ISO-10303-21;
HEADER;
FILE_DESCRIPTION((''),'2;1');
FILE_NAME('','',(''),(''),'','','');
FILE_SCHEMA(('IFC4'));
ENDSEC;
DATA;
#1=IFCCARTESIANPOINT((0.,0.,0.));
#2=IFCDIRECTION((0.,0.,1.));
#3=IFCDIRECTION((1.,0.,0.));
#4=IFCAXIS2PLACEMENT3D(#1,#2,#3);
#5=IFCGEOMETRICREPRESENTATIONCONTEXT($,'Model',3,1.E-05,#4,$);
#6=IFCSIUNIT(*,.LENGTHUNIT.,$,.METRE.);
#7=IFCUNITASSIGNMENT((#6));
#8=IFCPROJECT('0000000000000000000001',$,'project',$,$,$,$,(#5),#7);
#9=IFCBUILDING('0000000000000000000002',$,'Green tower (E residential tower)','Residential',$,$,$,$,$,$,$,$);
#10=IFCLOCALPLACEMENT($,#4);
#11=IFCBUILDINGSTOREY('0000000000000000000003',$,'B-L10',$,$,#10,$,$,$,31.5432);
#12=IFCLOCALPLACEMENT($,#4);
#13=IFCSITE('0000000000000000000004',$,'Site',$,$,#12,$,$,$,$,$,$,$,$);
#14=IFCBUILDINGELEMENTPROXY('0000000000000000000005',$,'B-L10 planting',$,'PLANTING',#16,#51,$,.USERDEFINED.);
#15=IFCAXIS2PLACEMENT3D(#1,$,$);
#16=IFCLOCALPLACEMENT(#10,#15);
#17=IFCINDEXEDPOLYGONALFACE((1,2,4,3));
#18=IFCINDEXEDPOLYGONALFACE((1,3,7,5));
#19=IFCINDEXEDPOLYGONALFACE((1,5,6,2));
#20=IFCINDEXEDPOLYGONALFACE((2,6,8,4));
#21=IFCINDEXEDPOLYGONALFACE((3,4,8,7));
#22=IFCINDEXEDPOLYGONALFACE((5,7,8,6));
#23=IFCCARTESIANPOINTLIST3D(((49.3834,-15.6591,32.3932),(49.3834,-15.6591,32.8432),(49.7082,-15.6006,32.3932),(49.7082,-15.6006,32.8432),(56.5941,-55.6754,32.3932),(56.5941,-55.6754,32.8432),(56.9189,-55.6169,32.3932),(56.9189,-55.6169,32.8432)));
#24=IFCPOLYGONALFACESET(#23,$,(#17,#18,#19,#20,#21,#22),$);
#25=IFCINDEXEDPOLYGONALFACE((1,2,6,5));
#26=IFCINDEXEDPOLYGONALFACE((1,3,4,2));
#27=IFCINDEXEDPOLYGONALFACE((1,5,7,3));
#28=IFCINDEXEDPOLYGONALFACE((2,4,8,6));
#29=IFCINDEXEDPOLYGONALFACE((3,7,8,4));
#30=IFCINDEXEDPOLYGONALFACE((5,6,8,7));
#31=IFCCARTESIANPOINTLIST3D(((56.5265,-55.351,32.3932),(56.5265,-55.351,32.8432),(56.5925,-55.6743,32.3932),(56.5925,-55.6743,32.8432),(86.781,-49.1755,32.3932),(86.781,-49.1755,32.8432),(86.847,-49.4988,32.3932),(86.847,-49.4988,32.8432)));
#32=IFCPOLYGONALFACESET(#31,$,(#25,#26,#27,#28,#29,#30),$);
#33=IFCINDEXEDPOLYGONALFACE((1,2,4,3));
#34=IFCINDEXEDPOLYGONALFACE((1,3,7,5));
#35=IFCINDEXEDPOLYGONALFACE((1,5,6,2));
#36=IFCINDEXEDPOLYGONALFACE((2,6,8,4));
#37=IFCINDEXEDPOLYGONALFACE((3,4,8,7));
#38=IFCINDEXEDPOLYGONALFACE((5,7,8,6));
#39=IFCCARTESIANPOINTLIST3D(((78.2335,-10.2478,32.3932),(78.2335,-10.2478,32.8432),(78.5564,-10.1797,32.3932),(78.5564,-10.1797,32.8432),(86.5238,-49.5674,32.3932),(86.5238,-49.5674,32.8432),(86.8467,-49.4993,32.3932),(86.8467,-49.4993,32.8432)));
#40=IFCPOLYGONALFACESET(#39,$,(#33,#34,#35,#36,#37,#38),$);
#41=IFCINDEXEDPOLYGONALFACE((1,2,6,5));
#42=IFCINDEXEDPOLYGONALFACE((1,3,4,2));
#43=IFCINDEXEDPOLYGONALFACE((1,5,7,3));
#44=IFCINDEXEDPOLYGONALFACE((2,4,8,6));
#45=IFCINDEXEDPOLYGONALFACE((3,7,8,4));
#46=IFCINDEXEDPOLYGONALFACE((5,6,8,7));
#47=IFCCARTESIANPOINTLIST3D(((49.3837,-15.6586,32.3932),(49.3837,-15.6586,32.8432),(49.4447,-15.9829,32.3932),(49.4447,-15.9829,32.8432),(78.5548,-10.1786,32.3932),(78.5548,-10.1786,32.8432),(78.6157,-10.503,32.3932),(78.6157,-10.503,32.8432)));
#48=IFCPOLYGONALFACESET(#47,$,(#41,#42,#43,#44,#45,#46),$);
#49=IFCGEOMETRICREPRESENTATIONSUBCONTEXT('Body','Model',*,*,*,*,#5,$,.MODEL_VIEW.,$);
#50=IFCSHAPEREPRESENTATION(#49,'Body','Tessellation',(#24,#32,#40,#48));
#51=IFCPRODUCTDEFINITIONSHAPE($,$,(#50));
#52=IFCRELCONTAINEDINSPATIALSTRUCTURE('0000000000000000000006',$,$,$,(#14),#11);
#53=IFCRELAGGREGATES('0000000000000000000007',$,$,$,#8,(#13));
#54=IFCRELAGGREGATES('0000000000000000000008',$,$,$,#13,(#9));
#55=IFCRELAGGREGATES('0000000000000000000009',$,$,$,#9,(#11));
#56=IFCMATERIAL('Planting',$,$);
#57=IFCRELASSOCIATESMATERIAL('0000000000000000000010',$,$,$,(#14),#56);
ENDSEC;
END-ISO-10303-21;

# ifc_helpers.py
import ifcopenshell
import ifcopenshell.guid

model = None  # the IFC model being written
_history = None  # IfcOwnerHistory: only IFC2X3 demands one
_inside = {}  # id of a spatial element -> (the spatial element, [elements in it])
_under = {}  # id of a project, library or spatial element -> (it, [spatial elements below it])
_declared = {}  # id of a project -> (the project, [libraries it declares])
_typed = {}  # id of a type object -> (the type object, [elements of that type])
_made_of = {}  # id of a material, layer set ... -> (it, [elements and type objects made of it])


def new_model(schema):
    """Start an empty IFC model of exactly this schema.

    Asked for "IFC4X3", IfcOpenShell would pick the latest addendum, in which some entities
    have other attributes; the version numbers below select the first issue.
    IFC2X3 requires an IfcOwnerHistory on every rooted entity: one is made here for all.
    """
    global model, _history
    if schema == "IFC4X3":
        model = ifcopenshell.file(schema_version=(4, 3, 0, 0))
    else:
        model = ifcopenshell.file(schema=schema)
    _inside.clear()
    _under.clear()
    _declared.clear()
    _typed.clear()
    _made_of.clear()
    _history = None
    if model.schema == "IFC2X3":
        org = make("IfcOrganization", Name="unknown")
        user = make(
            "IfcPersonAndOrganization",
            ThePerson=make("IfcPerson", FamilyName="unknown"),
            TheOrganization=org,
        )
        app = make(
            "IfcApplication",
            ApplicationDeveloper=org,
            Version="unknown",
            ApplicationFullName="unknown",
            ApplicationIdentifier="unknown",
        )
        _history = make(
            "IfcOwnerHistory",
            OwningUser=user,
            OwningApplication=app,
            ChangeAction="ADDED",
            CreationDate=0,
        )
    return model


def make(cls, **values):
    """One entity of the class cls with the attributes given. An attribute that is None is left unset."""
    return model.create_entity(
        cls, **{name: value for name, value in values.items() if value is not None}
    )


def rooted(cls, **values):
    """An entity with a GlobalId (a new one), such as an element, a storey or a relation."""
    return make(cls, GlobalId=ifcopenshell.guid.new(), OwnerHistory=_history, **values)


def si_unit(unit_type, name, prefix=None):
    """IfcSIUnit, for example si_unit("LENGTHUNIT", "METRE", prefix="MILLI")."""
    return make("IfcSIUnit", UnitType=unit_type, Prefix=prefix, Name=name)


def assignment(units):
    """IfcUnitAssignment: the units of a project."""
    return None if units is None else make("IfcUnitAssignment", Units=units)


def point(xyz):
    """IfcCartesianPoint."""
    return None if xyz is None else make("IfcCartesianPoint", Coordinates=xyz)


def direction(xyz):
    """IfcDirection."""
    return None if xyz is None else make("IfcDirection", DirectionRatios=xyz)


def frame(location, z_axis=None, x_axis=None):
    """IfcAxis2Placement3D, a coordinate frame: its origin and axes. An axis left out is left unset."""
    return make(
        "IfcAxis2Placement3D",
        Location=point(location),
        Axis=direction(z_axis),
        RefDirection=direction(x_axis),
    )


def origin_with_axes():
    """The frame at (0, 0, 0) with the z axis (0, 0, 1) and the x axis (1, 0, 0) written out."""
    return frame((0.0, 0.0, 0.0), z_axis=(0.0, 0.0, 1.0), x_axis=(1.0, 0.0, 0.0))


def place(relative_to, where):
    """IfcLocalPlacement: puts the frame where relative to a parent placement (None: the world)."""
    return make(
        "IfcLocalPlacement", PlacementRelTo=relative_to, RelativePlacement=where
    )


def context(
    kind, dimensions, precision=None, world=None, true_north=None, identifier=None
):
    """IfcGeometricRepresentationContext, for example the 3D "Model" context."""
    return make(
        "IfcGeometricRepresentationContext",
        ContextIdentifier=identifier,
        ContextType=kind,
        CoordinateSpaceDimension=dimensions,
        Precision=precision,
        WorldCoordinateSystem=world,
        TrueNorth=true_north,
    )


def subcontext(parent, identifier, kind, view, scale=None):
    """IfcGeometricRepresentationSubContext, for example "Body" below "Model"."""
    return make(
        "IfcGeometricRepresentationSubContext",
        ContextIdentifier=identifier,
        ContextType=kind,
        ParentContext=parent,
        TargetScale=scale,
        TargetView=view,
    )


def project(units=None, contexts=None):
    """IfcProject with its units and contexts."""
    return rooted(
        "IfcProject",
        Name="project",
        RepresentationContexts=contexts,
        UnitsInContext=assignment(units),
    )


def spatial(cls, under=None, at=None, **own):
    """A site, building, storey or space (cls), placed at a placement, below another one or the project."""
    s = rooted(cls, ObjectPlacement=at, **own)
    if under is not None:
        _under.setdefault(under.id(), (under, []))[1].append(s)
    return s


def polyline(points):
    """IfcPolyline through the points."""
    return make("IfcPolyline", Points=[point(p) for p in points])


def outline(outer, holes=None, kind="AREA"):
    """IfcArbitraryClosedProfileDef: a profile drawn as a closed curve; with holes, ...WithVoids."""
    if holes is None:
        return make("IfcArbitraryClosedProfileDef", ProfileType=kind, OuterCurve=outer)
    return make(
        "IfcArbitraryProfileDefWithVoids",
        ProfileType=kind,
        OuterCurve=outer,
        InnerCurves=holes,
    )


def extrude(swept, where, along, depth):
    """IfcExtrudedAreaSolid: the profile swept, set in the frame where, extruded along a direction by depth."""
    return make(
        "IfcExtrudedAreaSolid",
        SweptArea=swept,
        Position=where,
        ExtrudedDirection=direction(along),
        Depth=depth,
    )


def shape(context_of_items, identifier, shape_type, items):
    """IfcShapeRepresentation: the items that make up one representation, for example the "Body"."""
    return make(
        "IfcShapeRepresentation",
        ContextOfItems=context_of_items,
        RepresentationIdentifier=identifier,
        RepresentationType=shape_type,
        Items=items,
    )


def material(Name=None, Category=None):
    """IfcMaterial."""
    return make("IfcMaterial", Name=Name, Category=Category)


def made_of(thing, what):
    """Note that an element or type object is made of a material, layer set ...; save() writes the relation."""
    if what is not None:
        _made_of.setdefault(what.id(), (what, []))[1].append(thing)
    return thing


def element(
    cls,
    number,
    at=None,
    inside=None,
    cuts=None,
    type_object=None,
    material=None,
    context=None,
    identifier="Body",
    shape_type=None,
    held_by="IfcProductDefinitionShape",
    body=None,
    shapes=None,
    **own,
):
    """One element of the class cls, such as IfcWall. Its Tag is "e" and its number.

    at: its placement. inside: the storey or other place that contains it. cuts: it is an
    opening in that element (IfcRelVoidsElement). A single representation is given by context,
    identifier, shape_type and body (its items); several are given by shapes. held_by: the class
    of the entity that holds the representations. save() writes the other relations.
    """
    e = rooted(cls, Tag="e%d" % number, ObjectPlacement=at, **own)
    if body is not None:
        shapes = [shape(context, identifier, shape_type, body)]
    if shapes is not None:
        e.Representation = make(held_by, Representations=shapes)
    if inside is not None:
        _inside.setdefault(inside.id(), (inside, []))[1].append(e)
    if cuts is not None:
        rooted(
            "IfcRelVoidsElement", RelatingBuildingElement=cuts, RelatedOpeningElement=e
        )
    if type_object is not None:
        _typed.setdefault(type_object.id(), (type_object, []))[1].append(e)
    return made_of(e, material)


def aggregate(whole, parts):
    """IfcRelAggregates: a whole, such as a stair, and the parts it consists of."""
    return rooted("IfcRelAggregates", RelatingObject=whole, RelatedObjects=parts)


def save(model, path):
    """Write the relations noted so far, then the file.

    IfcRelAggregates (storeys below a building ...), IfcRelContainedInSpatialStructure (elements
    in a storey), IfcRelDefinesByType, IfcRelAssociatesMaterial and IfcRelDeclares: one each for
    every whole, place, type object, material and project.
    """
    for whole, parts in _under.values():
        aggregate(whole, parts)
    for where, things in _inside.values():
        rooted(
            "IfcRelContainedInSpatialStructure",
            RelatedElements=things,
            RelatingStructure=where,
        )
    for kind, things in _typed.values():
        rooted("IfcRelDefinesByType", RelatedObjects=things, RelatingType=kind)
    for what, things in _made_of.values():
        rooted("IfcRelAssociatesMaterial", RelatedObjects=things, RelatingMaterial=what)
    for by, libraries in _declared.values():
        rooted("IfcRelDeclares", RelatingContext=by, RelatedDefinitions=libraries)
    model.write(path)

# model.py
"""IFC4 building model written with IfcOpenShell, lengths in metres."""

from ifc_helpers import new_model, si_unit, frame, origin_with_axes, place, context, subcontext, project, spatial, polyline, outline, extrude, material, element, save


model = new_model("IFC4")

# Units and contexts
model_context = context("Model", 3, precision=1e-05, world=origin_with_axes())
body_context = subcontext(model_context, "Body", "Model", "MODEL_VIEW")
ifc_project = project(units=[si_unit("LENGTHUNIT", "METRE")], contexts=[model_context])

# Site, building, storey
site_placement = place(None, origin_with_axes())
site = spatial("IfcSite", under=ifc_project, at=site_placement, Name="Site")
building = spatial("IfcBuilding", under=site, Name="Green tower (E residential tower)", Description="Residential")
storey_placement = place(None, origin_with_axes())
storey = spatial("IfcBuildingStorey", under=building, at=storey_placement, Name="B-L10", Elevation=31.5432)

# Building element proxy
ifc_material_1 = material(Name="Planting")
proxy_1_placement = place(storey_placement, origin_with_axes())
element("IfcBuildingElementProxy", 1, at=proxy_1_placement, inside=storey, material=ifc_material_1, Name="B-L10 planting", ObjectType="PLANTING", PredefinedType="USERDEFINED", context=body_context, shape_type="SweptSolid", body=[
    extrude(outline(polyline([(49.3834, -15.6591), (56.5941, -55.6754), (56.9189, -55.6169), (49.7082, -15.6006), (49.3834, -15.6591)])), frame((0.0, 0.0, 32.3932), z_axis=(0.0, 0.0, 1.0), x_axis=(1.0, 0.0, 0.0)), (0.0, 0.0, 1.0), 0.45),
    extrude(outline(polyline([(56.5925, -55.6743), (86.847, -49.4988), (86.781, -49.1755), (56.5265, -55.351), (56.5925, -55.6743)])), frame((0.0, 0.0, 32.3932), z_axis=(0.0, 0.0, 1.0), x_axis=(1.0, 0.0, 0.0)), (0.0, 0.0, 1.0), 0.45),
    extrude(outline(polyline([(86.8467, -49.4993), (78.5564, -10.1797), (78.2335, -10.2478), (86.5238, -49.5674), (86.8467, -49.4993)])), frame((0.0, 0.0, 32.3932), z_axis=(0.0, 0.0, 1.0), x_axis=(1.0, 0.0, 0.0)), (0.0, 0.0, 1.0), 0.45),
    extrude(outline(polyline([(78.5548, -10.1786), (49.3837, -15.6586), (49.4447, -15.9829), (78.6157, -10.503), (78.5548, -10.1786)])), frame((0.0, 0.0, 32.3932), z_axis=(0.0, 0.0, 1.0), x_axis=(1.0, 0.0, 0.0)), (0.0, 0.0, 1.0), 0.45),
])

save(model, "model.ifc")
